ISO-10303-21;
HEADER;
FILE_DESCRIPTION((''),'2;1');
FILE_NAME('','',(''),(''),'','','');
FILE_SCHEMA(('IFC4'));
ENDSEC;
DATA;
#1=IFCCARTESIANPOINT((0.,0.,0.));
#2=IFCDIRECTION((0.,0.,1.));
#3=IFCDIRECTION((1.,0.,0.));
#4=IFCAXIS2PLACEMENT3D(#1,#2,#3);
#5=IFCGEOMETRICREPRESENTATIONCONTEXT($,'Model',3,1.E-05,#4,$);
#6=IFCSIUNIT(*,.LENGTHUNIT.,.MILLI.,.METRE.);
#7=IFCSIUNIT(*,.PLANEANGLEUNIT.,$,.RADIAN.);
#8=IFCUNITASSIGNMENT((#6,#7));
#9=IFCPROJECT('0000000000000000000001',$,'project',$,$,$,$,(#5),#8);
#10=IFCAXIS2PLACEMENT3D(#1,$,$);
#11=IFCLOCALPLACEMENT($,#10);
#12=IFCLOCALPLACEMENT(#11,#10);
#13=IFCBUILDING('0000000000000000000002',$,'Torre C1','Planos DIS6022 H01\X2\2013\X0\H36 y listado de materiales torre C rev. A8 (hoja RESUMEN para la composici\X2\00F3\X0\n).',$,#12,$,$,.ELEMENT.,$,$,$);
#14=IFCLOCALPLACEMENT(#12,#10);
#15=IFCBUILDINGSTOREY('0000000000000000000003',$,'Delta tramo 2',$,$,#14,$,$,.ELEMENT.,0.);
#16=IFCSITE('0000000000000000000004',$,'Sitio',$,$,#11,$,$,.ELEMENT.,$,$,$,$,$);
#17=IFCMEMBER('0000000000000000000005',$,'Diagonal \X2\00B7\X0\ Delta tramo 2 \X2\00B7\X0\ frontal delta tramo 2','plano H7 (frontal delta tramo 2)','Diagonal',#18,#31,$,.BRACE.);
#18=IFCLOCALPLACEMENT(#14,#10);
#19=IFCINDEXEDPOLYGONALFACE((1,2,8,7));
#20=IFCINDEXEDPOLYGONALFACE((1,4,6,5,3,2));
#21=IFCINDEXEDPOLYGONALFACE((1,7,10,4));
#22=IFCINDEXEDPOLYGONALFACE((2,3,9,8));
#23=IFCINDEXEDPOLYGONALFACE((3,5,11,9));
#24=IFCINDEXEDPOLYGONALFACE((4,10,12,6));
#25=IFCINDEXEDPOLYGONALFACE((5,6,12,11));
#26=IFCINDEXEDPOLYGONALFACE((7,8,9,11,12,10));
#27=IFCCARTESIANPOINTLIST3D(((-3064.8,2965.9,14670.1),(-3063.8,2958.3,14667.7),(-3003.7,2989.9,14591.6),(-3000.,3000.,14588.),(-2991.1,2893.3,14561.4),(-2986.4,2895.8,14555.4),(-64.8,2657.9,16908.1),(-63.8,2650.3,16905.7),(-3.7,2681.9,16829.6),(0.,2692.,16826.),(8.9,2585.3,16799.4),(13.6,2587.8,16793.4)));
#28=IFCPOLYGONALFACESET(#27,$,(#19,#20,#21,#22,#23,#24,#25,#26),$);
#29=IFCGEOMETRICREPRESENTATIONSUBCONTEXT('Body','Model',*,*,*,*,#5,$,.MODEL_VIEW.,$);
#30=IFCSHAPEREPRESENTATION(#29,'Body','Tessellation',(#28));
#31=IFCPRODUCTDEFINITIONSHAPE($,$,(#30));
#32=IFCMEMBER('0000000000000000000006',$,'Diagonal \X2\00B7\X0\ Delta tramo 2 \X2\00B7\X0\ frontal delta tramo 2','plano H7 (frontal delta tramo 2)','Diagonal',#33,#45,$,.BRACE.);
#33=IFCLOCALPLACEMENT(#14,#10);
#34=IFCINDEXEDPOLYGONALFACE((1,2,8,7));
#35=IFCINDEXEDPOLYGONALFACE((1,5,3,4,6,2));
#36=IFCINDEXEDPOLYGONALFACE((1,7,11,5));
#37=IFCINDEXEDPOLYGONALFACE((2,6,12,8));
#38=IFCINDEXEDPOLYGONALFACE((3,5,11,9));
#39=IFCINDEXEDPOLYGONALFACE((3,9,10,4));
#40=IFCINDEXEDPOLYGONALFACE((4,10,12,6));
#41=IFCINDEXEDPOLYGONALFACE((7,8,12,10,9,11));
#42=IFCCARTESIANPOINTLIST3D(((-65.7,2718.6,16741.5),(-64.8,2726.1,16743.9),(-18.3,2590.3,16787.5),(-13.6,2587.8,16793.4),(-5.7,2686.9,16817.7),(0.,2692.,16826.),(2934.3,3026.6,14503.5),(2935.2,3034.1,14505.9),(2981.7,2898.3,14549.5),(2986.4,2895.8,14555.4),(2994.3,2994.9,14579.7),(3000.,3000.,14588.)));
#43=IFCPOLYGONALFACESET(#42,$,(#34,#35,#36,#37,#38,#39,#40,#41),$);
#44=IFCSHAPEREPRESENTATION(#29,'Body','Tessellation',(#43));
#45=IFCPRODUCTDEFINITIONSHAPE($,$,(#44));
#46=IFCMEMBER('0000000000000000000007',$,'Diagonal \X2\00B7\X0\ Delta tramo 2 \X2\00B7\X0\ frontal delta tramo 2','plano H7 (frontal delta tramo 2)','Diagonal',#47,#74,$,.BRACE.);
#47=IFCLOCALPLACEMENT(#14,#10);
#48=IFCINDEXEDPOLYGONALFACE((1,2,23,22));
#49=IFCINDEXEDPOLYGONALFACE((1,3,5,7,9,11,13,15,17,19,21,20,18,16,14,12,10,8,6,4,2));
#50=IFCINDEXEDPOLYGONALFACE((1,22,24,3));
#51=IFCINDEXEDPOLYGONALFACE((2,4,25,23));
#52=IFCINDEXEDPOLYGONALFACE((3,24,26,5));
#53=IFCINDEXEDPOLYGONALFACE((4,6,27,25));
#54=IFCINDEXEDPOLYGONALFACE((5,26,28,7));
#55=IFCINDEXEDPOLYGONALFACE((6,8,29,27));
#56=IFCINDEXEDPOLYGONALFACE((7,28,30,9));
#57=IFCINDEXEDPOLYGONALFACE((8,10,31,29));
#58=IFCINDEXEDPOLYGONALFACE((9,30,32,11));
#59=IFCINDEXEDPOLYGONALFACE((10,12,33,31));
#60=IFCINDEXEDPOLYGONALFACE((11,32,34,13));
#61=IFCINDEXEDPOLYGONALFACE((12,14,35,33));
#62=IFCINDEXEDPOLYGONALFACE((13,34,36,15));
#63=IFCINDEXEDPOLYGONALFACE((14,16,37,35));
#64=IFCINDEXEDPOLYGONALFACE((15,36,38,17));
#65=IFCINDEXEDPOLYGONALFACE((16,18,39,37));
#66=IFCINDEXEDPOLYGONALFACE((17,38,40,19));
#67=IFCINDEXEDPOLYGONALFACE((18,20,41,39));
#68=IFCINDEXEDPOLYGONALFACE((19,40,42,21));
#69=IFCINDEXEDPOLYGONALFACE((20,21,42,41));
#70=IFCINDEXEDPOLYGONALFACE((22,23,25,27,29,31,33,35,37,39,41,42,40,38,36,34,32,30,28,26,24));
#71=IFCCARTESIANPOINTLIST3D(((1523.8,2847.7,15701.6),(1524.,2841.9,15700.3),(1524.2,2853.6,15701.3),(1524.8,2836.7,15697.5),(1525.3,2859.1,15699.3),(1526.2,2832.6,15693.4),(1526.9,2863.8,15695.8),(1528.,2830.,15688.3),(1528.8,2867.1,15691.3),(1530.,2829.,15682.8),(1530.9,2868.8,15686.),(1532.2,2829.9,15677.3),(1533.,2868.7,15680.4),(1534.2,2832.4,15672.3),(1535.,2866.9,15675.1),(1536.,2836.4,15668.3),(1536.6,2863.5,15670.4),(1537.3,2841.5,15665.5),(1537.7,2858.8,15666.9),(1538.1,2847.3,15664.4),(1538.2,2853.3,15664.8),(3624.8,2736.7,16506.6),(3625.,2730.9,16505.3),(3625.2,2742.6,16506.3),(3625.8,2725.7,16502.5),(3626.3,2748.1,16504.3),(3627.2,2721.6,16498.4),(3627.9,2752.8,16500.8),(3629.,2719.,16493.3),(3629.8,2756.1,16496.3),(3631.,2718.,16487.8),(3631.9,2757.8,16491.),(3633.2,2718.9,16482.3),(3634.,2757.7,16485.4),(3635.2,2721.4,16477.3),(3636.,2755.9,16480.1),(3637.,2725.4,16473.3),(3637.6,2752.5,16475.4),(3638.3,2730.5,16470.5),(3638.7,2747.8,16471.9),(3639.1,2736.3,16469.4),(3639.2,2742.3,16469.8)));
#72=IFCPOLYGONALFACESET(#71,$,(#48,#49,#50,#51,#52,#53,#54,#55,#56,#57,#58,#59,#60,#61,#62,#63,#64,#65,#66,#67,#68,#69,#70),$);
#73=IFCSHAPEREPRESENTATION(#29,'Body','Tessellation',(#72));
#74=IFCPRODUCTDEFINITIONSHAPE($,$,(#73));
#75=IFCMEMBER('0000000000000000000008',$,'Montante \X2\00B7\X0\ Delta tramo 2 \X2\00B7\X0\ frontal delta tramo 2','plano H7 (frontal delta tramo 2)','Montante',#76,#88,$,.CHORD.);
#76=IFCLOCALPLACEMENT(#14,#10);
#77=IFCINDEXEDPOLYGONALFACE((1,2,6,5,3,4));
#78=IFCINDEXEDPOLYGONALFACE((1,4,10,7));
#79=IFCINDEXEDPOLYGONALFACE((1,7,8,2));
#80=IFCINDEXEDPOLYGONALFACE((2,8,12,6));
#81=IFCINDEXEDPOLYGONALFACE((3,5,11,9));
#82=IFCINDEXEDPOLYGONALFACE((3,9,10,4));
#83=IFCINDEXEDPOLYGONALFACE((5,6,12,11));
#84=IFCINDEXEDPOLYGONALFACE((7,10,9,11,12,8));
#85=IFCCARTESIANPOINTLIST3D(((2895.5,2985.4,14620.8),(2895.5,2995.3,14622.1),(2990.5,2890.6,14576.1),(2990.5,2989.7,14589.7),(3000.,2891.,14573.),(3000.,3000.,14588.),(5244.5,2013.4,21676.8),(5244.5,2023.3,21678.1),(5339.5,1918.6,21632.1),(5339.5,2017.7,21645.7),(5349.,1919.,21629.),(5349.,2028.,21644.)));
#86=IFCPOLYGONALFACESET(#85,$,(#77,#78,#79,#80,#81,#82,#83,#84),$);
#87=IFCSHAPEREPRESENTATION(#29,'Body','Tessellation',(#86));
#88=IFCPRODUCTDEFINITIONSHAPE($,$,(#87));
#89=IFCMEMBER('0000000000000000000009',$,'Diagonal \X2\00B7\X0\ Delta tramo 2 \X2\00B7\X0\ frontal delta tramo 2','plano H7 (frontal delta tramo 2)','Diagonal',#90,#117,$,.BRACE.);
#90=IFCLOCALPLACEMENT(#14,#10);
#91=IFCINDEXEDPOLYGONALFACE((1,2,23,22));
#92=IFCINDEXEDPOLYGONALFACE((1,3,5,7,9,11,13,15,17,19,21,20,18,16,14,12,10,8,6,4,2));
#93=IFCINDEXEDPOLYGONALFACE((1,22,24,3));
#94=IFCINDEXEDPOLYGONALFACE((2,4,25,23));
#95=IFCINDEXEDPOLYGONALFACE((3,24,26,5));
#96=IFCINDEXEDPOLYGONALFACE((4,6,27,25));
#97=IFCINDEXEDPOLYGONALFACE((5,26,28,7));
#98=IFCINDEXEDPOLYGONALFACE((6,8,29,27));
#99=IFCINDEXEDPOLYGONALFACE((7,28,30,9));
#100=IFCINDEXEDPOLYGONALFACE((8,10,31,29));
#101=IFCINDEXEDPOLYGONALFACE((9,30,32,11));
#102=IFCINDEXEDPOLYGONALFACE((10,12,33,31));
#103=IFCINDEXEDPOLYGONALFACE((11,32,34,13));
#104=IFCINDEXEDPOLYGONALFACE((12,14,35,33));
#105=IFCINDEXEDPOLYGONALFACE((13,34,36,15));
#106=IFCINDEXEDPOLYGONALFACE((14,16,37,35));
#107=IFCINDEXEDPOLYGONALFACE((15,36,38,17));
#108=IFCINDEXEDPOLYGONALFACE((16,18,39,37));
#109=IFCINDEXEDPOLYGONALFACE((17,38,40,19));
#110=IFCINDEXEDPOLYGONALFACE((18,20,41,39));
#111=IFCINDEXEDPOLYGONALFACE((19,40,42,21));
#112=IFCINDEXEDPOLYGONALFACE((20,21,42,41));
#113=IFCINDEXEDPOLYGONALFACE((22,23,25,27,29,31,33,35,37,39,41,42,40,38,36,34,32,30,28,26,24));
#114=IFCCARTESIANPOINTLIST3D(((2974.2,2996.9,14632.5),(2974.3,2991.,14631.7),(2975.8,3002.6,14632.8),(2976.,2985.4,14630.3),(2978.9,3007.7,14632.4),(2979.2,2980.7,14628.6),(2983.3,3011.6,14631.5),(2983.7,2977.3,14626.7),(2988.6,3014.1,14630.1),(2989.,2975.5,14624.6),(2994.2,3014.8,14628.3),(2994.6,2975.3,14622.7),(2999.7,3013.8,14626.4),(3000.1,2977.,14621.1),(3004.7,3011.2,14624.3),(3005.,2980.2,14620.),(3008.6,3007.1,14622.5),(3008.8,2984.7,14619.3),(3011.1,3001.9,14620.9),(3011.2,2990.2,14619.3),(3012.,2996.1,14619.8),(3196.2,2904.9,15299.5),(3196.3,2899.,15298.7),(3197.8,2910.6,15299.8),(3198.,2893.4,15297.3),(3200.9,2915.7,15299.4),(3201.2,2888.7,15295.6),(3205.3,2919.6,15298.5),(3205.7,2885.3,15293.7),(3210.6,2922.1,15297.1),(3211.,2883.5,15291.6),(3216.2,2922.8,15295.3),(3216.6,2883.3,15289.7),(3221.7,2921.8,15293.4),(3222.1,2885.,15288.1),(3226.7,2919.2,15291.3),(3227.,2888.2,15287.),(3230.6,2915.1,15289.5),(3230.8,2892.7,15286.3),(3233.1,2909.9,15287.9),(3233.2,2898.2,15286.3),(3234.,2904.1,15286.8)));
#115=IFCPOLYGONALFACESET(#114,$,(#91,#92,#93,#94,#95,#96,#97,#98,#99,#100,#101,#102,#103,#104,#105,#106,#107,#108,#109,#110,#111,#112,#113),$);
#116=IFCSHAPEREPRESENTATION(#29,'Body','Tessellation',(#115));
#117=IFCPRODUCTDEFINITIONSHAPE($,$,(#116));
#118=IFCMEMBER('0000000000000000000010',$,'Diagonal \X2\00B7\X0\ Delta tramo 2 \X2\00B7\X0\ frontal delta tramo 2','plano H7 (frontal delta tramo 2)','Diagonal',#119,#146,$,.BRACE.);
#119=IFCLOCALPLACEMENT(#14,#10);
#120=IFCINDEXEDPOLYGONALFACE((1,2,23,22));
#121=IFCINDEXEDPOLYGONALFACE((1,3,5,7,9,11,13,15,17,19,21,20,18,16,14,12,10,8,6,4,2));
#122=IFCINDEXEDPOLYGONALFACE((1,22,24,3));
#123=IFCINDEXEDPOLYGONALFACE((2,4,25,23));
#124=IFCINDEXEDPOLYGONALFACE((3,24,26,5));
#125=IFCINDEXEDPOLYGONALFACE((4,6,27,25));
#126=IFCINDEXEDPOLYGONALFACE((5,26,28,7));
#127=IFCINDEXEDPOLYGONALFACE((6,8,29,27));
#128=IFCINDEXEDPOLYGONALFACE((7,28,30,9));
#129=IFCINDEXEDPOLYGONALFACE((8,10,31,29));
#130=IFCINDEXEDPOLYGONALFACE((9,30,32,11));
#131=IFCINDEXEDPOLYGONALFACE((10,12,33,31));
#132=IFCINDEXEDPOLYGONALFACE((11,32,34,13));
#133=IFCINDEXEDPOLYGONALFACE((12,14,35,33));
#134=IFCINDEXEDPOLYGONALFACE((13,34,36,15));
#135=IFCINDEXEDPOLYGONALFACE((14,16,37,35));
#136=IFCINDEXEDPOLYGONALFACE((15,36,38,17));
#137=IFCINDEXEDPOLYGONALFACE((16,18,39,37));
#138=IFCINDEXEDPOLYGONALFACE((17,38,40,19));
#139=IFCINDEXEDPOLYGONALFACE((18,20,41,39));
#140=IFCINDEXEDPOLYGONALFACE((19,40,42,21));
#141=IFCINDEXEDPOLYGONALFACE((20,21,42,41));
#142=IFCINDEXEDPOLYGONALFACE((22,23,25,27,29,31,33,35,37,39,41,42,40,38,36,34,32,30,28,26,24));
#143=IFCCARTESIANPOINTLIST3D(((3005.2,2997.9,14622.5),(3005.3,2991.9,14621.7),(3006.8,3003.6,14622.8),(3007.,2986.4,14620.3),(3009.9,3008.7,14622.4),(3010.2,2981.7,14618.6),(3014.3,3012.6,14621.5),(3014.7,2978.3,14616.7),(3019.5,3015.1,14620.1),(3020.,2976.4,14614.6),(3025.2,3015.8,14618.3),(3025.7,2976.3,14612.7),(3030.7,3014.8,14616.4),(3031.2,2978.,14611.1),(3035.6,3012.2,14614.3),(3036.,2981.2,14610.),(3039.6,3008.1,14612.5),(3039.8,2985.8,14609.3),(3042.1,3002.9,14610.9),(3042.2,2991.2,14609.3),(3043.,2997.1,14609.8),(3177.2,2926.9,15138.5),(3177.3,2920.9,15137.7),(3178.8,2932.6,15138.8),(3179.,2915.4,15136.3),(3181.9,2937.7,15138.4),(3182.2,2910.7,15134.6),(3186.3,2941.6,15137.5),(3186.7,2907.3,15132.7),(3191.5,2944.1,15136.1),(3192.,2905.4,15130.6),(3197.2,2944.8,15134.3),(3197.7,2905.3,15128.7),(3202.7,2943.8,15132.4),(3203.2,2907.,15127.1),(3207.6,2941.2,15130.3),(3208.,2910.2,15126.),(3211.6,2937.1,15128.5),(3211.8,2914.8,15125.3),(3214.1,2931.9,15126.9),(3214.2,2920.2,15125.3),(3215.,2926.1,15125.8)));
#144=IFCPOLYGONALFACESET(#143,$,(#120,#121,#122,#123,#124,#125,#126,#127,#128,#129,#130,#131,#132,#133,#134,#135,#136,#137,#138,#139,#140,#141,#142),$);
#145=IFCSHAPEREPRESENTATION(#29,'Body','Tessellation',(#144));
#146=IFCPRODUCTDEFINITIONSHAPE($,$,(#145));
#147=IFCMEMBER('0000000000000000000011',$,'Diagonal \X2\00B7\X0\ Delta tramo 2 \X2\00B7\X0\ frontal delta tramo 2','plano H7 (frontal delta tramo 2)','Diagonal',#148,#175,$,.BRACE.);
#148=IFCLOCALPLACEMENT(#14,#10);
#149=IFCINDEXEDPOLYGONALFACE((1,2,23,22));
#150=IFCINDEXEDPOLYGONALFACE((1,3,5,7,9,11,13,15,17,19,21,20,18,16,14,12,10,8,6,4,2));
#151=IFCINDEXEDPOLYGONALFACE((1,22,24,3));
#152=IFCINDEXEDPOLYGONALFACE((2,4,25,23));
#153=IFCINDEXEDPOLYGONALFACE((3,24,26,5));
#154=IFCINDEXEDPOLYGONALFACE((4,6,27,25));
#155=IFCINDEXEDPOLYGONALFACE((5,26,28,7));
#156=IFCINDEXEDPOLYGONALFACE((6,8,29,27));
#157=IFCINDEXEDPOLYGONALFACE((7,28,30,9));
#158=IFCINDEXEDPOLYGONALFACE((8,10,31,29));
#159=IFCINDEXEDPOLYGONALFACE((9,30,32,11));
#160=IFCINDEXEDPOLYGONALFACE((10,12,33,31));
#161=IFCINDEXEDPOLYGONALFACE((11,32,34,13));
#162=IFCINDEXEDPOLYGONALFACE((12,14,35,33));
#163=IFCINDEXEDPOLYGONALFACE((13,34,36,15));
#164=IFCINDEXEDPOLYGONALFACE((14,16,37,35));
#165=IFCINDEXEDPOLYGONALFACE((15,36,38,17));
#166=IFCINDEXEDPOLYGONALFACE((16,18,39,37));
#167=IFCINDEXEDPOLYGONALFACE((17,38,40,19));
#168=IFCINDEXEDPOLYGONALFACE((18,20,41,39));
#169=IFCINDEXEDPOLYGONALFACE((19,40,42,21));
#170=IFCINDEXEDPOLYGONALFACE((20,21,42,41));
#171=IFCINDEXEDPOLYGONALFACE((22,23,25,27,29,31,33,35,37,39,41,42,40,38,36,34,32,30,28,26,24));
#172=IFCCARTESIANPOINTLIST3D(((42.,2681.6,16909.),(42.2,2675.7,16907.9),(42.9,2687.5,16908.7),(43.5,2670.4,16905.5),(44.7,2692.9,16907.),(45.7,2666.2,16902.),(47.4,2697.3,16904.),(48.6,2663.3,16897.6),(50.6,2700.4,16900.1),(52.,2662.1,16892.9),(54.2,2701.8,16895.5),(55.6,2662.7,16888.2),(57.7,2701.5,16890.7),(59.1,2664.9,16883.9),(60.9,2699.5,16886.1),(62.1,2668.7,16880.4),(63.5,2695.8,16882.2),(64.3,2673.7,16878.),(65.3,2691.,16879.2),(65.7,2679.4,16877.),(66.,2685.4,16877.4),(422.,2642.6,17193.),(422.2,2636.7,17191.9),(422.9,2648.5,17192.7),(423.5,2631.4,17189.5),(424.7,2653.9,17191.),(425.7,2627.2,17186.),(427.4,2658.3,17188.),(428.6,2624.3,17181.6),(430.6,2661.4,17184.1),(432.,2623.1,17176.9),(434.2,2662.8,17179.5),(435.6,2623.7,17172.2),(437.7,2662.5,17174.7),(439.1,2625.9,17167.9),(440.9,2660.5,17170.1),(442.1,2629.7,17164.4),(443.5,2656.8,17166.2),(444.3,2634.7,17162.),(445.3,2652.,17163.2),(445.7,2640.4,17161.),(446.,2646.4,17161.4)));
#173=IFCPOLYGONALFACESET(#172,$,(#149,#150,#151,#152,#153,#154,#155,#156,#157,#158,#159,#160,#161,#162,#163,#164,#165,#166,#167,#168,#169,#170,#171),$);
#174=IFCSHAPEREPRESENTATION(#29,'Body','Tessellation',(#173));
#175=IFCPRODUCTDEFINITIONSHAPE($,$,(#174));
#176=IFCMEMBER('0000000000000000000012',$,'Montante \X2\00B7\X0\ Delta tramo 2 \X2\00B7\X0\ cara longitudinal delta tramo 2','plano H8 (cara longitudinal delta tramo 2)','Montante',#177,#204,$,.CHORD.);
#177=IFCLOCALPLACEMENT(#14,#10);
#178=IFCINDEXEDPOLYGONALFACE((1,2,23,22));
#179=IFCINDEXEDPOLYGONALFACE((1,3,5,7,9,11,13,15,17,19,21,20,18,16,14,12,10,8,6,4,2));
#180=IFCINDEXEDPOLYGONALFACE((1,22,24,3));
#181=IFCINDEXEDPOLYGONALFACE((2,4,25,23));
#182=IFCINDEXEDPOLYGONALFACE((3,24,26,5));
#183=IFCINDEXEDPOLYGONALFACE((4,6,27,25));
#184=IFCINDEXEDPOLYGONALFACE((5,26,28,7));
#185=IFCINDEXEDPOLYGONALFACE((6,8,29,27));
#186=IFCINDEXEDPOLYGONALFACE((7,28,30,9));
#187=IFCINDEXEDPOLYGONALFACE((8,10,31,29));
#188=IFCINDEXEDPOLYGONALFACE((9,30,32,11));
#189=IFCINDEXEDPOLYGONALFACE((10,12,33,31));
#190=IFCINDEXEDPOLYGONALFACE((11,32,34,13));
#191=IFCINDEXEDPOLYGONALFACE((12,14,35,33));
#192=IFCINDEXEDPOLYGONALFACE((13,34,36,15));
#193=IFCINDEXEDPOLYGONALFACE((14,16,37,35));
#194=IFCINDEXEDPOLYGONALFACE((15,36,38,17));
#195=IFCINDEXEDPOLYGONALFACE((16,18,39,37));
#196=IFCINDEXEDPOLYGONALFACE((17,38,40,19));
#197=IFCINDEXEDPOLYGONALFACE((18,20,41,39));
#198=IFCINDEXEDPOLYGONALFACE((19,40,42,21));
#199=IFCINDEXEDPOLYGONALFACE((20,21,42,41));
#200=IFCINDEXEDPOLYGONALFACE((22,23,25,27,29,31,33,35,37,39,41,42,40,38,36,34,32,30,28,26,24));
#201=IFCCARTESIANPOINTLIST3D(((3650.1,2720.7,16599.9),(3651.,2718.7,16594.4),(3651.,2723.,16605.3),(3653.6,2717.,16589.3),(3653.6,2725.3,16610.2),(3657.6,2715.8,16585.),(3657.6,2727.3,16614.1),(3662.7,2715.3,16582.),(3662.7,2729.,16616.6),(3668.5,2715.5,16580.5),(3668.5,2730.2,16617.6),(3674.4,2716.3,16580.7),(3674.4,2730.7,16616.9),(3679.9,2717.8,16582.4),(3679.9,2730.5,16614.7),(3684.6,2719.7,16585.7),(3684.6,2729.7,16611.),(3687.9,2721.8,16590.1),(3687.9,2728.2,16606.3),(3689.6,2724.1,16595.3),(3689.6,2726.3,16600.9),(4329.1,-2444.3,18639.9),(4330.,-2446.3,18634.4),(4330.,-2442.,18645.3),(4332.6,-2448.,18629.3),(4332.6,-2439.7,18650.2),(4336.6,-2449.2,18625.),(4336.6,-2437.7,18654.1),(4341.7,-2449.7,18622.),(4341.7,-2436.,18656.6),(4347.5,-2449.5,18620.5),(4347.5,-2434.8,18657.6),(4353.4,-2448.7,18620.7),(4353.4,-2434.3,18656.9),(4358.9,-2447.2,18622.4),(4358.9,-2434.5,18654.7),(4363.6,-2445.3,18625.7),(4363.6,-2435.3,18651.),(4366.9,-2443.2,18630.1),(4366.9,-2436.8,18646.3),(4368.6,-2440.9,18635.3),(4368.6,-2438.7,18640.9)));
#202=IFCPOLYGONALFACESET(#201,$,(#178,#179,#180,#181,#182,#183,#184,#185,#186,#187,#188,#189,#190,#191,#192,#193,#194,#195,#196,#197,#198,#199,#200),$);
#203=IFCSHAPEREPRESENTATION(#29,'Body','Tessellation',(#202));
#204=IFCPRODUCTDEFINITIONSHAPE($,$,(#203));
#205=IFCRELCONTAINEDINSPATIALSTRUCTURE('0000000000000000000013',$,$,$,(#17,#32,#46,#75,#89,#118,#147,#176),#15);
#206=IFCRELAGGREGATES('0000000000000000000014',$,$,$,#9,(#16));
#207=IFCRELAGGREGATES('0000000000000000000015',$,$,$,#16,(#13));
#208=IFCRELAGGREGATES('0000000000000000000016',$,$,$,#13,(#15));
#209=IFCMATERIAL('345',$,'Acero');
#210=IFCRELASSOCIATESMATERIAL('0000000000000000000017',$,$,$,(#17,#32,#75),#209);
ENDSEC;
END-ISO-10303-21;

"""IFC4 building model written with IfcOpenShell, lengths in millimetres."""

from ifc_helpers import new_model, si_unit, frame, frame_2d, origin, origin_with_axes, place, context, subcontext, project, spatial, circle, l_section, extrude, material, element, save


model = new_model("IFC4")

# Units and contexts
model_context = context("Model", 3, precision=1e-05, world=origin_with_axes())
body_context = subcontext(model_context, "Body", "Model", "MODEL_VIEW")
ifc_project = project(units=[si_unit("LENGTHUNIT", "METRE", prefix="MILLI"), si_unit("PLANEANGLEUNIT", "RADIAN")], contexts=[model_context])

# Site, building, storey
site_placement = place(None, origin())
site = spatial("IfcSite", under=ifc_project, at=site_placement, Name="Sitio", CompositionType="ELEMENT")
building_placement = place(site_placement, origin())
building = spatial("IfcBuilding", under=site, at=building_placement, Name="Torre C1", Description="Planos DIS6022 H01–H36 y listado de materiales torre C rev. A8 (hoja RESUMEN para la composición).", CompositionType="ELEMENT")
storey_placement = place(building_placement, origin())
storey = spatial("IfcBuildingStorey", under=building, at=storey_placement, Name="Delta tramo 2", CompositionType="ELEMENT", Elevation=0.0)

# Members
ifc_material_1 = material(Name="345", Category="Acero")
member_1_placement = place(storey_placement, frame((0.0, 2692.0, 16826.0), z_axis=(-0.798836, 0.082014, -0.595932), x_axis=(0.123685, -0.947102, -0.29614)))
element("IfcMember", 1, at=member_1_placement, inside=storey, material=ifc_material_1, Name="Diagonal · Delta tramo 2 · frontal delta tramo 2", Description="plano H7 (frontal delta tramo 2)", ObjectType="Diagonal", PredefinedType="BRACE", context=body_context, shape_type="SweptSolid", body=[
    extrude(l_section(Depth=110.0, Width=110.0, Thickness=8.0, at=frame_2d((55.0, 55.0))), None, (0.0, 0.0, 1.0), 3755.5),
])
member_2_placement = place(storey_placement, frame((0.0, 2692.0, 16826.0), z_axis=(0.798836, 0.082014, -0.595932), x_axis=(-0.123685, -0.947102, -0.29614)))
element("IfcMember", 2, at=member_2_placement, inside=storey, material=ifc_material_1, Name="Diagonal · Delta tramo 2 · frontal delta tramo 2", Description="plano H7 (frontal delta tramo 2)", ObjectType="Diagonal", PredefinedType="BRACE", context=body_context, shape_type="SweptSolid", body=[
    extrude(l_section(Depth=110.0, Width=110.0, Thickness=8.0, at=frame_2d((55.0, 55.0))), None, (0.0, 0.0, 1.0), 3755.5),
])
member_3_placement = place(storey_placement, frame((1531.0, 2849.0, 15683.0), z_axis=(0.932669, -0.049275, 0.357353), x_axis=(-0.152133, -0.95195, 0.265794)))
element("IfcMember", 3, at=member_3_placement, inside=storey, Name="Diagonal · Delta tramo 2 · frontal delta tramo 2", Description="plano H7 (frontal delta tramo 2)", ObjectType="Diagonal", PredefinedType="BRACE", context=body_context, shape_type="SweptSolid", body=[
    extrude(circle(Radius=20.0), None, (0.0, 0.0, 1.0), 2252.7),
])
member_4_placement = place(storey_placement, frame((3000.0, 3000.0, 14588.0), z_axis=(0.313201, -0.1296, 0.940802), x_axis=(-0.949687, -0.042741, 0.310271)))
element("IfcMember", 4, at=member_4_placement, inside=storey, material=ifc_material_1, Name="Montante · Delta tramo 2 · frontal delta tramo 2", Description="plano H7 (frontal delta tramo 2)", ObjectType="Montante", PredefinedType="CHORD", context=body_context, shape_type="SweptSolid", body=[
    extrude(l_section(Depth=110.0, Width=110.0, Thickness=10.0, at=frame_2d((55.0, 55.0))), None, (0.0, 0.0, 1.0), 7500.0),
])
member_5_placement = place(storey_placement, frame((2993.0, 2995.0, 14626.0), z_axis=(0.313131, -0.129766, 0.940803), x_axis=(-0.688431, -0.713424, 0.13073)))
element("IfcMember", 5, at=member_5_placement, inside=storey, Name="Diagonal · Delta tramo 2 · frontal delta tramo 2", Description="plano H7 (frontal delta tramo 2)", ObjectType="Diagonal", PredefinedType="BRACE", context=body_context, shape_type="SweptSolid", body=[
    extrude(circle(Radius=20.0), None, (0.0, 0.0, 1.0), 709.0),
])
member_6_placement = place(storey_placement, frame((3024.0, 2996.0, 14616.0), z_axis=(0.313568, -0.129438, 0.940703), x_axis=(-0.687636, -0.71415, 0.130947)))
element("IfcMember", 6, at=member_6_placement, inside=storey, Name="Diagonal · Delta tramo 2 · frontal delta tramo 2", Description="plano H7 (frontal delta tramo 2)", ObjectType="Diagonal", PredefinedType="BRACE", context=body_context, shape_type="SweptSolid", body=[
    extrude(circle(Radius=20.0), None, (0.0, 0.0, 1.0), 548.5),
])
member_7_placement = place(storey_placement, frame((434.0, 2643.0, 17177.0), z_axis=(-0.798318, 0.081933, -0.596637), x_axis=(-0.098238, -0.995149, -0.005212)))
element("IfcMember", 7, at=member_7_placement, inside=storey, Name="Diagonal · Delta tramo 2 · frontal delta tramo 2", Description="plano H7 (frontal delta tramo 2)", ObjectType="Diagonal", PredefinedType="BRACE", context=body_context, shape_type="SweptSolid", body=[
    extrude(circle(Radius=20.0), None, (0.0, 0.0, 1.0), 476.0),
])
member_8_placement = place(storey_placement, frame((3670.0, 2723.0, 16599.0), z_axis=(0.121366, -0.923207, 0.364635), x_axis=(-0.992608, -0.112881, 0.044584)))
element("IfcMember", 8, at=member_8_placement, inside=storey, Name="Montante · Delta tramo 2 · cara longitudinal delta tramo 2", Description="plano H8 (cara longitudinal delta tramo 2)", ObjectType="Montante", PredefinedType="CHORD", context=body_context, shape_type="SweptSolid", body=[
    extrude(circle(Radius=20.0), None, (0.0, 0.0, 1.0), 5594.6),
])

save(model, "model.ifc")
